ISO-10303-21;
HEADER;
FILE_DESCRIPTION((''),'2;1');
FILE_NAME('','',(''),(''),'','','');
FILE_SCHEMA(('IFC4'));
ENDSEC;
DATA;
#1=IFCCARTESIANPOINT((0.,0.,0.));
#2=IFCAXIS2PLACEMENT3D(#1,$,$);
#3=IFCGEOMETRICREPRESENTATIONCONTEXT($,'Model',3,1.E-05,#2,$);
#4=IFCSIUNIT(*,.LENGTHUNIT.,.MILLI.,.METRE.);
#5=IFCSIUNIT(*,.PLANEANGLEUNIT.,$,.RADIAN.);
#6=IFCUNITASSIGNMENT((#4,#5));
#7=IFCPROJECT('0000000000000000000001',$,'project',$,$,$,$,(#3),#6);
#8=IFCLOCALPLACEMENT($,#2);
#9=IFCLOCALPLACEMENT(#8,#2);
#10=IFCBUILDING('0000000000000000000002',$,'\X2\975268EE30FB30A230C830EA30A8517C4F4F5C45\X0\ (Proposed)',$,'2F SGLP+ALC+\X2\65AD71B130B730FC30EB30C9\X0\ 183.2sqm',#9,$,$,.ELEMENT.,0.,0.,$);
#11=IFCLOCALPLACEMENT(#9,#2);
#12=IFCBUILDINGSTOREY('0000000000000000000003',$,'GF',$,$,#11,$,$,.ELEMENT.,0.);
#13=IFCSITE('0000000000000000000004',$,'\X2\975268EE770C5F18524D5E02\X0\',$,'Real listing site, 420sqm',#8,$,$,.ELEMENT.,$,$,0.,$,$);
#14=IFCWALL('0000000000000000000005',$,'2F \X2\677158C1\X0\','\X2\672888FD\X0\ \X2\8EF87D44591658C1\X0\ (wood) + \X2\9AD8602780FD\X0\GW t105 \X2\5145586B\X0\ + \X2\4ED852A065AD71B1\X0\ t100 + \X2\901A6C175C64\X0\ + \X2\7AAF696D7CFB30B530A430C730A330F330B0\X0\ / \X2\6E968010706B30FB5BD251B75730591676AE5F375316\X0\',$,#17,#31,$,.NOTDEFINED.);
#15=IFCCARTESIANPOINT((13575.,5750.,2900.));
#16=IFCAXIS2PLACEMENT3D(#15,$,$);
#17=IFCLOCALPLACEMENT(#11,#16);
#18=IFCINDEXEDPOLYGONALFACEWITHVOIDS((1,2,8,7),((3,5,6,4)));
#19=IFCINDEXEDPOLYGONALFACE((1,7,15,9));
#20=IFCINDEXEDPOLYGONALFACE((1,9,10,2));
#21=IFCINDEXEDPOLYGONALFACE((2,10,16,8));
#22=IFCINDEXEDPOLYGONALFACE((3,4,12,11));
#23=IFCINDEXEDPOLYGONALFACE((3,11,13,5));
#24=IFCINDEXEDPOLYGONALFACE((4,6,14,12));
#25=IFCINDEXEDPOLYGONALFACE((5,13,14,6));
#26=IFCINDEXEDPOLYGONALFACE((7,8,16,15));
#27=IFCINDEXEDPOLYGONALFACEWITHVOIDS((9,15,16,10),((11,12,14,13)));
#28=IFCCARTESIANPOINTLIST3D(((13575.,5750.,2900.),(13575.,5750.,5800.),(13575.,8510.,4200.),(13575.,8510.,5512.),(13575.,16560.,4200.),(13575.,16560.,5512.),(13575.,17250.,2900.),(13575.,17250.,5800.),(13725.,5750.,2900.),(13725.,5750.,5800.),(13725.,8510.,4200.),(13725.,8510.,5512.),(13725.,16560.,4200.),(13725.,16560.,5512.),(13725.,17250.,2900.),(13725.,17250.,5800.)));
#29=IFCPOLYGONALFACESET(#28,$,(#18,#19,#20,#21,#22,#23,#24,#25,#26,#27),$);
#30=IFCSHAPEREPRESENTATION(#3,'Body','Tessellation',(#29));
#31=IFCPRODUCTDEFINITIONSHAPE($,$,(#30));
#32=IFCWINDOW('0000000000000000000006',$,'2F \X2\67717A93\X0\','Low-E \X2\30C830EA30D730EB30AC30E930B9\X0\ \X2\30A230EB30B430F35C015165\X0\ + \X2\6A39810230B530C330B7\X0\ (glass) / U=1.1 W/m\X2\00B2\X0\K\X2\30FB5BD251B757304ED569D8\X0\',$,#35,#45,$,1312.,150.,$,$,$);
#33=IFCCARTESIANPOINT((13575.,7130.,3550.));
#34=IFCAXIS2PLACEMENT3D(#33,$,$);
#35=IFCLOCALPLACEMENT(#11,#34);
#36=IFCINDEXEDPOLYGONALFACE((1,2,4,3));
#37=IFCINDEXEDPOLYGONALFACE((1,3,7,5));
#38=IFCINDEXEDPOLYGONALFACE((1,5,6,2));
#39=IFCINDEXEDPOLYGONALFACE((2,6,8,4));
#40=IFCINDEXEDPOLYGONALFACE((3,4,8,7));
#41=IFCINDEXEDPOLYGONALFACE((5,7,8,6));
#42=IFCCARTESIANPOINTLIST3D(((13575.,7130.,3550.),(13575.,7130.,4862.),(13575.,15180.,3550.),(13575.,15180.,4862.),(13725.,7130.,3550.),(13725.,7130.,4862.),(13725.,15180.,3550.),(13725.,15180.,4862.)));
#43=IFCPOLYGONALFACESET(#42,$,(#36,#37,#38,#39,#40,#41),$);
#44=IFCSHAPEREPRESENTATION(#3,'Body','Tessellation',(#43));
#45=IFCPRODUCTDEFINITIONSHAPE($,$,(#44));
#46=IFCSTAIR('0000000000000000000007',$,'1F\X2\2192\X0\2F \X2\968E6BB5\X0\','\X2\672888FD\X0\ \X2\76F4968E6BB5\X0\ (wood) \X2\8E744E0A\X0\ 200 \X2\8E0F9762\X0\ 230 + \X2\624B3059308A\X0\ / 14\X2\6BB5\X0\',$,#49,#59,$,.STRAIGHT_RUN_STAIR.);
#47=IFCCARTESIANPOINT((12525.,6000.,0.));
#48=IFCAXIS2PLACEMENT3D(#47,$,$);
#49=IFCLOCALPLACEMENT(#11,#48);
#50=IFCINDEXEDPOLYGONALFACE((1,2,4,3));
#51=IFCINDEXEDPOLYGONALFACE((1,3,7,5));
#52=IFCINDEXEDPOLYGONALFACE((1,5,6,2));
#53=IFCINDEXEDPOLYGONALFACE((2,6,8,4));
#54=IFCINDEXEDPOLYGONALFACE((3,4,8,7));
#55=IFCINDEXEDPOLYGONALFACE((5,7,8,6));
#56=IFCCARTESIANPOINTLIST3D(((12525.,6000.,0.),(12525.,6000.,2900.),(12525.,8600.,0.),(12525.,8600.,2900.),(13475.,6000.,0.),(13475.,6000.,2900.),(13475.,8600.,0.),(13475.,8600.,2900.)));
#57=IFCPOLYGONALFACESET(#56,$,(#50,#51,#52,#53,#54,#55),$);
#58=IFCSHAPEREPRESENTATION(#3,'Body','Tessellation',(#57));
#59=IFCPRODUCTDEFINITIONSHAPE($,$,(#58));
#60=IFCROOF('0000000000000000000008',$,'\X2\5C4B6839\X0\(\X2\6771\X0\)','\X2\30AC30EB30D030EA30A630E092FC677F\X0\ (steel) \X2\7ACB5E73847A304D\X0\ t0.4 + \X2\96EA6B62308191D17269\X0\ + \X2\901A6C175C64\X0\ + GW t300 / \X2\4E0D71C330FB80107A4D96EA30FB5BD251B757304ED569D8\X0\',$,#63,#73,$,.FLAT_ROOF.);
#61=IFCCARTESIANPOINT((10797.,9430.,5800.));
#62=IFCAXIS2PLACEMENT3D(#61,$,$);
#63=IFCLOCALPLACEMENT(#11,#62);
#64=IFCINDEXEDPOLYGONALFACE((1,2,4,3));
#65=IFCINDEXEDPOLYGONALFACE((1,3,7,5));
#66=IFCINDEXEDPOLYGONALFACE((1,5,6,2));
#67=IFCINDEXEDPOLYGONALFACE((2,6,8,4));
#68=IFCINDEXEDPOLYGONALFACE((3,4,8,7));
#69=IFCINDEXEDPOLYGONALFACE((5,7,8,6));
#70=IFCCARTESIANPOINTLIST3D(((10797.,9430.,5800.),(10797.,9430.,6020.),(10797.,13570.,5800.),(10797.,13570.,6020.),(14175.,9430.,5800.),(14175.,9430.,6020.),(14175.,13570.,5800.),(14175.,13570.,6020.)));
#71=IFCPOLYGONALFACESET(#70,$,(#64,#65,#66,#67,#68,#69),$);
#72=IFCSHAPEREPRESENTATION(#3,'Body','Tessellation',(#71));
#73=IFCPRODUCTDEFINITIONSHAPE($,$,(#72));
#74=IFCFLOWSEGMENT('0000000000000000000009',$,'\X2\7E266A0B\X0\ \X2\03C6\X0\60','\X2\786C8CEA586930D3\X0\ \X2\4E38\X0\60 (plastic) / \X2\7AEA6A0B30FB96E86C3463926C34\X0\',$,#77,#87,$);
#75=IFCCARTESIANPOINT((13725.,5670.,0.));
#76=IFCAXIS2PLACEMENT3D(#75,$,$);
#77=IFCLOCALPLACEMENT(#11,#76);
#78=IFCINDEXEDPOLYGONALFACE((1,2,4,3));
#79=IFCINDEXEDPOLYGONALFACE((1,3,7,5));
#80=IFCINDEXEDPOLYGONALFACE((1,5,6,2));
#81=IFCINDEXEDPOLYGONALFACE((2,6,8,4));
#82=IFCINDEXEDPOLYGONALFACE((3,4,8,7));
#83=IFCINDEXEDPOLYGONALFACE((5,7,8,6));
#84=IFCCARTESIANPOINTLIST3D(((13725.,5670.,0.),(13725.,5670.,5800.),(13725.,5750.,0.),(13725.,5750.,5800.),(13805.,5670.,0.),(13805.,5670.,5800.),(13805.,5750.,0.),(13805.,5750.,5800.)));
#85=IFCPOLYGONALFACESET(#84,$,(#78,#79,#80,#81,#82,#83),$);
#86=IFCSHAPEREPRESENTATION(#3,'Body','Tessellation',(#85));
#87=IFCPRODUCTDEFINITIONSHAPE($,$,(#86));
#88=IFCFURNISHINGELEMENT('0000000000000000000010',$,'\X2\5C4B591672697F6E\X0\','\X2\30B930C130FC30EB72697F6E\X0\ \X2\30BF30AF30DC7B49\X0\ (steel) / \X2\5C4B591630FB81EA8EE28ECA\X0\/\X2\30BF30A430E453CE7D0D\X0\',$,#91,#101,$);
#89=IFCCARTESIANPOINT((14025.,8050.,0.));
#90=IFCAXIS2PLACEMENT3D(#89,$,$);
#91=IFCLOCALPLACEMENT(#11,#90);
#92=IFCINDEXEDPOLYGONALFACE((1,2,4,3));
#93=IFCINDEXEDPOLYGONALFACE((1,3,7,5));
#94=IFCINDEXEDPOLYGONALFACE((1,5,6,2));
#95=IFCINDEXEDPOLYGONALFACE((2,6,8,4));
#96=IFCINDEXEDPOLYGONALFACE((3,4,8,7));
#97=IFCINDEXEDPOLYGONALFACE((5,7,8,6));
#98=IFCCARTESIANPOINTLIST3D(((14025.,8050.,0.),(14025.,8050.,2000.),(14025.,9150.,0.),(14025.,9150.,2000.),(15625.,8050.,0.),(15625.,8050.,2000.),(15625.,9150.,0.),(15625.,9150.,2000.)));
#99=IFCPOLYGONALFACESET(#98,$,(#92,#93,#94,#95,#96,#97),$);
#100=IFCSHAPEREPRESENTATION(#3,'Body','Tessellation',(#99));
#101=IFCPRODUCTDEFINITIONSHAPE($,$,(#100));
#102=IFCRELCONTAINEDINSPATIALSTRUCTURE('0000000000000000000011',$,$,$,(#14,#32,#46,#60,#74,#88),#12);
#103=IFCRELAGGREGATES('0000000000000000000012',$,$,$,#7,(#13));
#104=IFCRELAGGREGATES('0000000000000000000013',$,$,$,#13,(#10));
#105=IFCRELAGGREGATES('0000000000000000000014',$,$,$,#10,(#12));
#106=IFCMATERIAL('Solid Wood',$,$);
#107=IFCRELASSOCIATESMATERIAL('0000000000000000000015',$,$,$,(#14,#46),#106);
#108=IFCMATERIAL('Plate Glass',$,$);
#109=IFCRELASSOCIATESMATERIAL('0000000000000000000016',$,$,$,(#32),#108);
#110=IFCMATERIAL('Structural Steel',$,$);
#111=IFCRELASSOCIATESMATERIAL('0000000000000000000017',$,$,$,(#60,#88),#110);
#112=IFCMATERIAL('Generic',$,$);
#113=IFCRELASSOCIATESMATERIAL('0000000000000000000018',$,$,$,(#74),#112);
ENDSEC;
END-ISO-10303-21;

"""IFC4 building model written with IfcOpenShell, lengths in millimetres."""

from ifc_helpers import new_model, si_unit, frame, frame_2d, origin, place, context, project, spatial, rectangle, extrude, material, element, fill, save


model = new_model("IFC4")

# Units and contexts
model_context = context("Model", 3, precision=1e-05, world=origin())
ifc_project = project(units=[si_unit("LENGTHUNIT", "METRE", prefix="MILLI"), si_unit("PLANEANGLEUNIT", "RADIAN")], contexts=[model_context])

# Site, building, storey
site_placement = place(None, origin())
site = spatial("IfcSite", under=ifc_project, at=site_placement, Name="青森県弘前市", ObjectType="Real listing site, 420sqm", CompositionType="ELEMENT", RefElevation=0.0)
building_placement = place(site_placement, origin())
building = spatial("IfcBuilding", under=site, at=building_placement, Name="青森・アトリエ兼住居 (Proposed)", ObjectType="2F SGLP+ALC+断熱シールド 183.2sqm", CompositionType="ELEMENT", ElevationOfRefHeight=0.0, ElevationOfTerrain=0.0)
storey_placement = place(building_placement, origin())
storey = spatial("IfcBuildingStorey", under=building, at=storey_placement, Name="GF", CompositionType="ELEMENT", Elevation=0.0)

# Shared definitions
ifc_material_1 = material(Name="Solid Wood")

# Wall, opening, window
ifc_material_2 = material(Name="Plate Glass")
wall_1_placement = place(storey_placement, frame((13575.0, 5750.0, 2900.0)))
wall_1 = element("IfcWall", 1, at=wall_1_placement, inside=storey, material=ifc_material_1, Name="2F 東壁", Description="木製 軸組外壁 (wood) + 高性能GW t105 充填 + 付加断熱 t100 + 通気層 + 窯業系サイディング / 準耐火・寒冷地外皮強化", PredefinedType="NOTDEFINED", context=model_context, shape_type="SweptSolid", body=[
    extrude(rectangle(XDim=150.0, YDim=11500.0, at=frame_2d((75.0, 5750.0))), frame((13575.0, 5750.0, 2900.0)), (0.0, 0.0, 1.0), 2900.0),
])
opening_1_placement = place(storey_placement, frame((13575.0, 7130.0, 3550.0)))
opening_1 = element("IfcOpeningElement", 2, at=opening_1_placement, cuts=wall_1, PredefinedType="NOTDEFINED", context=model_context, shape_type="SweptSolid", body=[
    extrude(rectangle(XDim=150.0, YDim=8050.0, at=frame_2d((75.0, 4025.0))), frame((13575.0, 7130.0, 3550.0)), (0.0, 0.0, 1.0), 1312.0),
])
window_1_placement = place(storey_placement, frame((13575.0, 7130.0, 3550.0)))
window_1 = element("IfcWindow", 3, at=window_1_placement, inside=storey, material=ifc_material_2, Name="2F 東窓", Description="Low-E トリプルガラス アルゴン封入 + 樹脂サッシ (glass) / U=1.1 W/m²K・寒冷地仕様", OverallHeight=1312.0, OverallWidth=150.0, context=model_context, shape_type="SweptSolid", body=[
    extrude(rectangle(XDim=150.0, YDim=8050.0, at=frame_2d((75.0, 4025.0))), frame((13575.0, 7130.0, 3550.0)), (0.0, 0.0, 1.0), 1312.0),
])
fill(opening_1, window_1)

# Stair
stair_placement = place(storey_placement, frame((12525.0, 6000.0, 0.0)))
element("IfcStair", 4, at=stair_placement, inside=storey, material=ifc_material_1, Name="1F→2F 階段", Description="木製 直階段 (wood) 蹴上 200 踏面 230 + 手すり / 14段", PredefinedType="STRAIGHT_RUN_STAIR", context=model_context, shape_type="SweptSolid", body=[
    extrude(rectangle(XDim=950.0, YDim=2600.0, at=frame_2d((475.0, 1300.0))), frame((12525.0, 6000.0, 0.0)), (0.0, 0.0, 1.0), 2900.0),
])

# Roof
ifc_material_3 = material(Name="Structural Steel")
roof_placement = place(storey_placement, frame((10797.0, 9430.0, 5800.0)))
element("IfcRoof", 5, at=roof_placement, inside=storey, material=ifc_material_3, Name="屋根(東)", Description="ガルバリウム鋼板 (steel) 立平葺き t0.4 + 雪止め金物 + 通気層 + GW t300 / 不燃・耐積雪・寒冷地仕様", PredefinedType="FLAT_ROOF", context=model_context, shape_type="SweptSolid", body=[
    extrude(rectangle(XDim=3378.0, YDim=4140.0, at=frame_2d((1689.0, 2070.0))), frame((10797.0, 9430.0, 5800.0)), (0.0, 0.0, 1.0), 220.0),
])

# Flow segment
ifc_material_4 = material(Name="Generic")
flow_segment_placement = place(storey_placement, frame((13725.0, 5670.0, 0.0)))
element("IfcFlowSegment", 6, at=flow_segment_placement, inside=storey, material=ifc_material_4, Name="縦樋 φ60", Description="硬質塩ビ 丸60 (plastic) / 竪樋・雨水排水", context=model_context, shape_type="SweptSolid", body=[
    extrude(rectangle(XDim=80.0, YDim=80.0, at=frame_2d((40.0, 40.0))), frame((13725.0, 5670.0, 0.0)), (0.0, 0.0, 1.0), 5800.0),
])

# Furnishing element
furnishing_placement = place(storey_placement, frame((14025.0, 8050.0, 0.0)))
element("IfcFurnishingElement", 7, at=furnishing_placement, inside=storey, material=ifc_material_3, Name="屋外物置", Description="スチール物置 タクボ等 (steel) / 屋外・自転車/タイヤ収納", context=model_context, shape_type="SweptSolid", body=[
    extrude(rectangle(XDim=1600.0, YDim=1100.0, at=frame_2d((800.0, 550.0))), frame((14025.0, 8050.0, 0.0)), (0.0, 0.0, 1.0), 2000.0),
])

save(model, "model.ifc")
